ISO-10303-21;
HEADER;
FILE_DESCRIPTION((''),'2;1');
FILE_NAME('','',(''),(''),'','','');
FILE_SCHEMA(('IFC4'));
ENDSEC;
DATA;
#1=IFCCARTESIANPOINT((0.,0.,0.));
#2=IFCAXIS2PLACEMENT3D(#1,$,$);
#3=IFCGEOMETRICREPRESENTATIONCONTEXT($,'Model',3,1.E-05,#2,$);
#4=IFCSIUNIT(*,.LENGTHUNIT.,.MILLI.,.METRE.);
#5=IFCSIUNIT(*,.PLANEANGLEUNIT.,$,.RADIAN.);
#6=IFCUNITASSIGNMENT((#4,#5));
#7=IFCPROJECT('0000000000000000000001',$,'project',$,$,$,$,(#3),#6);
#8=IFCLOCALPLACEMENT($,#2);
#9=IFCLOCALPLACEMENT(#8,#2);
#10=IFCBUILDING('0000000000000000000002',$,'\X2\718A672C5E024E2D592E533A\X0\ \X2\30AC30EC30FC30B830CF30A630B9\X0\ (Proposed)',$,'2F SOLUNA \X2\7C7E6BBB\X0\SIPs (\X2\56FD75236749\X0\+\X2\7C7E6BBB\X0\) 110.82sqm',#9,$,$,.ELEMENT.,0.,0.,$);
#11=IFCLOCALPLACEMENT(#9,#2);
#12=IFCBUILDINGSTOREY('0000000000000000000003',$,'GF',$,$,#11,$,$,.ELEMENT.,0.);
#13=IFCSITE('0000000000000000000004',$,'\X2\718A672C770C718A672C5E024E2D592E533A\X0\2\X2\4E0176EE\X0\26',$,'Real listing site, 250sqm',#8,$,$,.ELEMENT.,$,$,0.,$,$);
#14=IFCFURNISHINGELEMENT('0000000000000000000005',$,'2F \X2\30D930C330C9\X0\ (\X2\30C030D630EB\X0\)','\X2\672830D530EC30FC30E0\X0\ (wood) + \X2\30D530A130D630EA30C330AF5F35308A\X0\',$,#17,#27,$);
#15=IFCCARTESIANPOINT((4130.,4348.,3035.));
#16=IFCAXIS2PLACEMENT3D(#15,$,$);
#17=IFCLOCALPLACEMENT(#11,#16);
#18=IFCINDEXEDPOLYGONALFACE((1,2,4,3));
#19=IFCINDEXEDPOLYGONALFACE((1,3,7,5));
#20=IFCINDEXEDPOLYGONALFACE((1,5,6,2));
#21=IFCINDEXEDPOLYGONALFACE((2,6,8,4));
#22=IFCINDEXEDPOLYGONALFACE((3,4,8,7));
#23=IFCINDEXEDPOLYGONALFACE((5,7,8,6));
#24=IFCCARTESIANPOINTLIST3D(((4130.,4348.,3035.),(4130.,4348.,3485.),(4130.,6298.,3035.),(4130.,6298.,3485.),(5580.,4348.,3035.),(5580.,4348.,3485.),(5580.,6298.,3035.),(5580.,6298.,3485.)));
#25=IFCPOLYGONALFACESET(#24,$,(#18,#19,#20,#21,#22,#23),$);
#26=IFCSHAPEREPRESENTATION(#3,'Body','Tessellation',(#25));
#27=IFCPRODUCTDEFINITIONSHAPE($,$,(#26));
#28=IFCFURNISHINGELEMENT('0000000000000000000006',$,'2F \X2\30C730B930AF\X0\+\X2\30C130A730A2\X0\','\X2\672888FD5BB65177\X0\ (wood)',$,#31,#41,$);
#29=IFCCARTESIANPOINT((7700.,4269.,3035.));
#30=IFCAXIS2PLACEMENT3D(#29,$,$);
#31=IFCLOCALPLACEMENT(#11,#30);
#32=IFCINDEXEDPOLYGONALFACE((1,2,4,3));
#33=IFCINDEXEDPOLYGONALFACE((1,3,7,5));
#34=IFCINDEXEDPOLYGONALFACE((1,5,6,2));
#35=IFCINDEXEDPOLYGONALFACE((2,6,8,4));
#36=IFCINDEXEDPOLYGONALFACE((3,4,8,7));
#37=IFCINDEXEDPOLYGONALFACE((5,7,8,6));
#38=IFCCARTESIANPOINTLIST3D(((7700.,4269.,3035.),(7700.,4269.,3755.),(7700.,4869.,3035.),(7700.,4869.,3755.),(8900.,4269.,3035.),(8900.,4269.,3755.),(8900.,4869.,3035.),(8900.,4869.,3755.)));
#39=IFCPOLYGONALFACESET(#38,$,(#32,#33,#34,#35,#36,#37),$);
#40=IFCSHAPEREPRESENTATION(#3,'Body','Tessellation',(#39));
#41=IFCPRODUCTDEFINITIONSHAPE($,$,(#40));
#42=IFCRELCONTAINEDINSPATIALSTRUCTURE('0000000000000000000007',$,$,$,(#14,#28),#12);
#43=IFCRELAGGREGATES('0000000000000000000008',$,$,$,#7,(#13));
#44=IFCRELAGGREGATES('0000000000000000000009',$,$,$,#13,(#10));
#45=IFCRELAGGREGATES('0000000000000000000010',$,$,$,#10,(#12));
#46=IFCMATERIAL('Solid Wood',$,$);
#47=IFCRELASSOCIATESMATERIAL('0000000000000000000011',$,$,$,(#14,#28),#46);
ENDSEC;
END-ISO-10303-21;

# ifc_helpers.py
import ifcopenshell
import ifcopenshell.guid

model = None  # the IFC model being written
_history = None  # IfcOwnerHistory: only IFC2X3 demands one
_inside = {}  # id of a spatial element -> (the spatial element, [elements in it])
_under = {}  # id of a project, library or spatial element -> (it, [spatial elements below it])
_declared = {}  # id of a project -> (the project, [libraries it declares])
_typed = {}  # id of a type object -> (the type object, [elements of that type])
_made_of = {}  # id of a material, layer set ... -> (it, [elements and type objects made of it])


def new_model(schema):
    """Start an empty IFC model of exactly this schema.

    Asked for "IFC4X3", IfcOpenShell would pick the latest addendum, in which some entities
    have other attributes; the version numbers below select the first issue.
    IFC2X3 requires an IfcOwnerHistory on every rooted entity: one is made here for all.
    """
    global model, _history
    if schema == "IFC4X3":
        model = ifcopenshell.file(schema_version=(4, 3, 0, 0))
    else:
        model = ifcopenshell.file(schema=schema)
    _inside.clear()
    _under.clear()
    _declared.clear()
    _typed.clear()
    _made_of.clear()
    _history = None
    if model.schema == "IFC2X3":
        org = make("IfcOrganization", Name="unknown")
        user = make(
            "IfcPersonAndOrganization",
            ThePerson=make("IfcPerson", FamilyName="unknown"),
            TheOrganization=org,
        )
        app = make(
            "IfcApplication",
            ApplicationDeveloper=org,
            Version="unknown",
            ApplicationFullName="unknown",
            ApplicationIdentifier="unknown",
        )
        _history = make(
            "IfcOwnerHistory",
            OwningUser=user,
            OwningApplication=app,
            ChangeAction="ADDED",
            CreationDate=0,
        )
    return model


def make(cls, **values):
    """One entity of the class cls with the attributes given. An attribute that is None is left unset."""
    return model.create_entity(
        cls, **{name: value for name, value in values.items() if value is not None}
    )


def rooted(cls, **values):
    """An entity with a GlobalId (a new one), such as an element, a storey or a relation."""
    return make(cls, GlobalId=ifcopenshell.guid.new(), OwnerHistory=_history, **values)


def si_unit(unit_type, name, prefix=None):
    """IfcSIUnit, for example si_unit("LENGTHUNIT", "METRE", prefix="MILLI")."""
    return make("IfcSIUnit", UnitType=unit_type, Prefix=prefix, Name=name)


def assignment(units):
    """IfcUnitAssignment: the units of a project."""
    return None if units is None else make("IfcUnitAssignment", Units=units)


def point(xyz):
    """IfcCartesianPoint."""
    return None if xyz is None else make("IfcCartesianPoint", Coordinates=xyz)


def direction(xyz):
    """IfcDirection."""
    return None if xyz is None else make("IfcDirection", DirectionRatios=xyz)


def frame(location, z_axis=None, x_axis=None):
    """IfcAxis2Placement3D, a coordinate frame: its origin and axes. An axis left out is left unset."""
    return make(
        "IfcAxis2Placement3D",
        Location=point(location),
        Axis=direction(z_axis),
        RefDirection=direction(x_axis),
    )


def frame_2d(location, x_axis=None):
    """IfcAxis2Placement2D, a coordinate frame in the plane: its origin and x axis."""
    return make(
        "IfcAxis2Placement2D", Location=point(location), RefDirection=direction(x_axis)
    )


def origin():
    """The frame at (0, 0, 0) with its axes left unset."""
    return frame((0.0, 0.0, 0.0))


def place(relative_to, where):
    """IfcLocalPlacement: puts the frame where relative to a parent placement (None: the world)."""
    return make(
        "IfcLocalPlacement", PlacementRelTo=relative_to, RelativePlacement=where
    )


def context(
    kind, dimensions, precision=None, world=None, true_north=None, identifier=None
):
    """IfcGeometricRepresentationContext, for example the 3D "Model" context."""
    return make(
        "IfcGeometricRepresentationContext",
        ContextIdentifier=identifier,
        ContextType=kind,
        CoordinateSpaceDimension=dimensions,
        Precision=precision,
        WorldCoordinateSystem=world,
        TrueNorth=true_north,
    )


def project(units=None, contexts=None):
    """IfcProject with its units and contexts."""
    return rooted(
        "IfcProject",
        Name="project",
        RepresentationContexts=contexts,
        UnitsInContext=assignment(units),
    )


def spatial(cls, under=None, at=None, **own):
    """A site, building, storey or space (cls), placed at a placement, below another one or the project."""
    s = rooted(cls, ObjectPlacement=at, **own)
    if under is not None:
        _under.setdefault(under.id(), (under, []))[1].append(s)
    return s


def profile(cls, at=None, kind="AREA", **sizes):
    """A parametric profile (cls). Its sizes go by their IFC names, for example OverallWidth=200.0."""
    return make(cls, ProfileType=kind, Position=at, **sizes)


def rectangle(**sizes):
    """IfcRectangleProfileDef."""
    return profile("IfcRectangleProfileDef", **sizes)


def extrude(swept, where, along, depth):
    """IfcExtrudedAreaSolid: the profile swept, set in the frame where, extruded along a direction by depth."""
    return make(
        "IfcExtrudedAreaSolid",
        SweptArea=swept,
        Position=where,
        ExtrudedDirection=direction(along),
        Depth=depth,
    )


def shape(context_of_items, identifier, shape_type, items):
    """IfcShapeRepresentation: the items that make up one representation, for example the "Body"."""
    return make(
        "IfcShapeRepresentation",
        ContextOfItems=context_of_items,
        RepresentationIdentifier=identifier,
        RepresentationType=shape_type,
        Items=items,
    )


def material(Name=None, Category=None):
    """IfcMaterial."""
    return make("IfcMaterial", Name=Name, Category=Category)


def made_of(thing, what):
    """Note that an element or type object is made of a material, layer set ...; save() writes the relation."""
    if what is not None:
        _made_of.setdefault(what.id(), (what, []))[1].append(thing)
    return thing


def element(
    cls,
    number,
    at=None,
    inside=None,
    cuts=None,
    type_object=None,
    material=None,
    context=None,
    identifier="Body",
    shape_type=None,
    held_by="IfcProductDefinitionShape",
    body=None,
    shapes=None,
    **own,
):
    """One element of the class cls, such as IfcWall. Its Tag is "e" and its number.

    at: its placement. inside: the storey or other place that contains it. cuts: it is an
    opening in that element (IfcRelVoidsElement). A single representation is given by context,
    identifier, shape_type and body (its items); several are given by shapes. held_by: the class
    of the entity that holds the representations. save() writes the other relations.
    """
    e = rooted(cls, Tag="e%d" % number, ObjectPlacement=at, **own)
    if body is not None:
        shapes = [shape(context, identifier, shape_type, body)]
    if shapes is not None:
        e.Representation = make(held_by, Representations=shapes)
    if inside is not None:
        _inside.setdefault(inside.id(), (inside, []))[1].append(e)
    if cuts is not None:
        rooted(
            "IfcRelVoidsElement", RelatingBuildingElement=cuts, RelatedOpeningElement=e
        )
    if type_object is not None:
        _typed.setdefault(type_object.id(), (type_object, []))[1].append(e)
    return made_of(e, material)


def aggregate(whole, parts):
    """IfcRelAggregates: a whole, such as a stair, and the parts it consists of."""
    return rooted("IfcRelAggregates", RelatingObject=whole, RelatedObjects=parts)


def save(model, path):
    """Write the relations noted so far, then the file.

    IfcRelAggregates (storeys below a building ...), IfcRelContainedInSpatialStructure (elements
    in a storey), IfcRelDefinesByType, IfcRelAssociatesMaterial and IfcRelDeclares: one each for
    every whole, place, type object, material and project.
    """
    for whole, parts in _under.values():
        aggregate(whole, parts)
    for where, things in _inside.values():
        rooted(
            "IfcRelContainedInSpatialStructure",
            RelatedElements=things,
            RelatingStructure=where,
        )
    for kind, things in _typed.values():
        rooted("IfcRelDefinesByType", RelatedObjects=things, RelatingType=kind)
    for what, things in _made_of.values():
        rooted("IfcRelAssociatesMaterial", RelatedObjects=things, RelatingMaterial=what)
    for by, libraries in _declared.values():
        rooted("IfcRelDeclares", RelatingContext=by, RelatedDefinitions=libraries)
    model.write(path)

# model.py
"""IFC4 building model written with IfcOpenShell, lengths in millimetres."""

from ifc_helpers import new_model, si_unit, frame, frame_2d, origin, place, context, project, spatial, rectangle, extrude, material, element, save


model = new_model("IFC4")

# Units and contexts
model_context = context("Model", 3, precision=1e-05, world=origin())
ifc_project = project(units=[si_unit("LENGTHUNIT", "METRE", prefix="MILLI"), si_unit("PLANEANGLEUNIT", "RADIAN")], contexts=[model_context])

# Site, building, storey
site_placement = place(None, origin())
site = spatial("IfcSite", under=ifc_project, at=site_placement, Name="熊本県熊本市中央区2丁目26", ObjectType="Real listing site, 250sqm", CompositionType="ELEMENT", RefElevation=0.0)
building_placement = place(site_placement, origin())
building = spatial("IfcBuilding", under=site, at=building_placement, Name="熊本市中央区 ガレージハウス (Proposed)", ObjectType="2F SOLUNA 籾殻SIPs (国産杉+籾殻) 110.82sqm", CompositionType="ELEMENT", ElevationOfRefHeight=0.0, ElevationOfTerrain=0.0)
storey_placement = place(building_placement, origin())
storey = spatial("IfcBuildingStorey", under=building, at=storey_placement, Name="GF", CompositionType="ELEMENT", Elevation=0.0)

# Shared definitions
ifc_material_1 = material(Name="Solid Wood")

# Furnishing elements
furnishing_1_placement = place(storey_placement, frame((4130.0, 4348.0, 3035.0)))
element("IfcFurnishingElement", 1, at=furnishing_1_placement, inside=storey, material=ifc_material_1, Name="2F ベッド (ダブル)", Description="木フレーム (wood) + ファブリック張り", context=model_context, shape_type="SweptSolid", body=[
    extrude(rectangle(XDim=1450.0, YDim=1950.0, at=frame_2d((725.0, 975.0))), frame((4130.0, 4348.0, 3035.0)), (0.0, 0.0, 1.0), 450.0),
])
furnishing_2_placement = place(storey_placement, frame((7700.0, 4269.0, 3035.0)))
element("IfcFurnishingElement", 2, at=furnishing_2_placement, inside=storey, material=ifc_material_1, Name="2F デスク+チェア", Description="木製家具 (wood)", context=model_context, shape_type="SweptSolid", body=[
    extrude(rectangle(XDim=1200.0, YDim=600.0, at=frame_2d((600.0, 300.0))), frame((7700.0, 4269.0, 3035.0)), (0.0, 0.0, 1.0), 720.0),
])

save(model, "model.ifc")
